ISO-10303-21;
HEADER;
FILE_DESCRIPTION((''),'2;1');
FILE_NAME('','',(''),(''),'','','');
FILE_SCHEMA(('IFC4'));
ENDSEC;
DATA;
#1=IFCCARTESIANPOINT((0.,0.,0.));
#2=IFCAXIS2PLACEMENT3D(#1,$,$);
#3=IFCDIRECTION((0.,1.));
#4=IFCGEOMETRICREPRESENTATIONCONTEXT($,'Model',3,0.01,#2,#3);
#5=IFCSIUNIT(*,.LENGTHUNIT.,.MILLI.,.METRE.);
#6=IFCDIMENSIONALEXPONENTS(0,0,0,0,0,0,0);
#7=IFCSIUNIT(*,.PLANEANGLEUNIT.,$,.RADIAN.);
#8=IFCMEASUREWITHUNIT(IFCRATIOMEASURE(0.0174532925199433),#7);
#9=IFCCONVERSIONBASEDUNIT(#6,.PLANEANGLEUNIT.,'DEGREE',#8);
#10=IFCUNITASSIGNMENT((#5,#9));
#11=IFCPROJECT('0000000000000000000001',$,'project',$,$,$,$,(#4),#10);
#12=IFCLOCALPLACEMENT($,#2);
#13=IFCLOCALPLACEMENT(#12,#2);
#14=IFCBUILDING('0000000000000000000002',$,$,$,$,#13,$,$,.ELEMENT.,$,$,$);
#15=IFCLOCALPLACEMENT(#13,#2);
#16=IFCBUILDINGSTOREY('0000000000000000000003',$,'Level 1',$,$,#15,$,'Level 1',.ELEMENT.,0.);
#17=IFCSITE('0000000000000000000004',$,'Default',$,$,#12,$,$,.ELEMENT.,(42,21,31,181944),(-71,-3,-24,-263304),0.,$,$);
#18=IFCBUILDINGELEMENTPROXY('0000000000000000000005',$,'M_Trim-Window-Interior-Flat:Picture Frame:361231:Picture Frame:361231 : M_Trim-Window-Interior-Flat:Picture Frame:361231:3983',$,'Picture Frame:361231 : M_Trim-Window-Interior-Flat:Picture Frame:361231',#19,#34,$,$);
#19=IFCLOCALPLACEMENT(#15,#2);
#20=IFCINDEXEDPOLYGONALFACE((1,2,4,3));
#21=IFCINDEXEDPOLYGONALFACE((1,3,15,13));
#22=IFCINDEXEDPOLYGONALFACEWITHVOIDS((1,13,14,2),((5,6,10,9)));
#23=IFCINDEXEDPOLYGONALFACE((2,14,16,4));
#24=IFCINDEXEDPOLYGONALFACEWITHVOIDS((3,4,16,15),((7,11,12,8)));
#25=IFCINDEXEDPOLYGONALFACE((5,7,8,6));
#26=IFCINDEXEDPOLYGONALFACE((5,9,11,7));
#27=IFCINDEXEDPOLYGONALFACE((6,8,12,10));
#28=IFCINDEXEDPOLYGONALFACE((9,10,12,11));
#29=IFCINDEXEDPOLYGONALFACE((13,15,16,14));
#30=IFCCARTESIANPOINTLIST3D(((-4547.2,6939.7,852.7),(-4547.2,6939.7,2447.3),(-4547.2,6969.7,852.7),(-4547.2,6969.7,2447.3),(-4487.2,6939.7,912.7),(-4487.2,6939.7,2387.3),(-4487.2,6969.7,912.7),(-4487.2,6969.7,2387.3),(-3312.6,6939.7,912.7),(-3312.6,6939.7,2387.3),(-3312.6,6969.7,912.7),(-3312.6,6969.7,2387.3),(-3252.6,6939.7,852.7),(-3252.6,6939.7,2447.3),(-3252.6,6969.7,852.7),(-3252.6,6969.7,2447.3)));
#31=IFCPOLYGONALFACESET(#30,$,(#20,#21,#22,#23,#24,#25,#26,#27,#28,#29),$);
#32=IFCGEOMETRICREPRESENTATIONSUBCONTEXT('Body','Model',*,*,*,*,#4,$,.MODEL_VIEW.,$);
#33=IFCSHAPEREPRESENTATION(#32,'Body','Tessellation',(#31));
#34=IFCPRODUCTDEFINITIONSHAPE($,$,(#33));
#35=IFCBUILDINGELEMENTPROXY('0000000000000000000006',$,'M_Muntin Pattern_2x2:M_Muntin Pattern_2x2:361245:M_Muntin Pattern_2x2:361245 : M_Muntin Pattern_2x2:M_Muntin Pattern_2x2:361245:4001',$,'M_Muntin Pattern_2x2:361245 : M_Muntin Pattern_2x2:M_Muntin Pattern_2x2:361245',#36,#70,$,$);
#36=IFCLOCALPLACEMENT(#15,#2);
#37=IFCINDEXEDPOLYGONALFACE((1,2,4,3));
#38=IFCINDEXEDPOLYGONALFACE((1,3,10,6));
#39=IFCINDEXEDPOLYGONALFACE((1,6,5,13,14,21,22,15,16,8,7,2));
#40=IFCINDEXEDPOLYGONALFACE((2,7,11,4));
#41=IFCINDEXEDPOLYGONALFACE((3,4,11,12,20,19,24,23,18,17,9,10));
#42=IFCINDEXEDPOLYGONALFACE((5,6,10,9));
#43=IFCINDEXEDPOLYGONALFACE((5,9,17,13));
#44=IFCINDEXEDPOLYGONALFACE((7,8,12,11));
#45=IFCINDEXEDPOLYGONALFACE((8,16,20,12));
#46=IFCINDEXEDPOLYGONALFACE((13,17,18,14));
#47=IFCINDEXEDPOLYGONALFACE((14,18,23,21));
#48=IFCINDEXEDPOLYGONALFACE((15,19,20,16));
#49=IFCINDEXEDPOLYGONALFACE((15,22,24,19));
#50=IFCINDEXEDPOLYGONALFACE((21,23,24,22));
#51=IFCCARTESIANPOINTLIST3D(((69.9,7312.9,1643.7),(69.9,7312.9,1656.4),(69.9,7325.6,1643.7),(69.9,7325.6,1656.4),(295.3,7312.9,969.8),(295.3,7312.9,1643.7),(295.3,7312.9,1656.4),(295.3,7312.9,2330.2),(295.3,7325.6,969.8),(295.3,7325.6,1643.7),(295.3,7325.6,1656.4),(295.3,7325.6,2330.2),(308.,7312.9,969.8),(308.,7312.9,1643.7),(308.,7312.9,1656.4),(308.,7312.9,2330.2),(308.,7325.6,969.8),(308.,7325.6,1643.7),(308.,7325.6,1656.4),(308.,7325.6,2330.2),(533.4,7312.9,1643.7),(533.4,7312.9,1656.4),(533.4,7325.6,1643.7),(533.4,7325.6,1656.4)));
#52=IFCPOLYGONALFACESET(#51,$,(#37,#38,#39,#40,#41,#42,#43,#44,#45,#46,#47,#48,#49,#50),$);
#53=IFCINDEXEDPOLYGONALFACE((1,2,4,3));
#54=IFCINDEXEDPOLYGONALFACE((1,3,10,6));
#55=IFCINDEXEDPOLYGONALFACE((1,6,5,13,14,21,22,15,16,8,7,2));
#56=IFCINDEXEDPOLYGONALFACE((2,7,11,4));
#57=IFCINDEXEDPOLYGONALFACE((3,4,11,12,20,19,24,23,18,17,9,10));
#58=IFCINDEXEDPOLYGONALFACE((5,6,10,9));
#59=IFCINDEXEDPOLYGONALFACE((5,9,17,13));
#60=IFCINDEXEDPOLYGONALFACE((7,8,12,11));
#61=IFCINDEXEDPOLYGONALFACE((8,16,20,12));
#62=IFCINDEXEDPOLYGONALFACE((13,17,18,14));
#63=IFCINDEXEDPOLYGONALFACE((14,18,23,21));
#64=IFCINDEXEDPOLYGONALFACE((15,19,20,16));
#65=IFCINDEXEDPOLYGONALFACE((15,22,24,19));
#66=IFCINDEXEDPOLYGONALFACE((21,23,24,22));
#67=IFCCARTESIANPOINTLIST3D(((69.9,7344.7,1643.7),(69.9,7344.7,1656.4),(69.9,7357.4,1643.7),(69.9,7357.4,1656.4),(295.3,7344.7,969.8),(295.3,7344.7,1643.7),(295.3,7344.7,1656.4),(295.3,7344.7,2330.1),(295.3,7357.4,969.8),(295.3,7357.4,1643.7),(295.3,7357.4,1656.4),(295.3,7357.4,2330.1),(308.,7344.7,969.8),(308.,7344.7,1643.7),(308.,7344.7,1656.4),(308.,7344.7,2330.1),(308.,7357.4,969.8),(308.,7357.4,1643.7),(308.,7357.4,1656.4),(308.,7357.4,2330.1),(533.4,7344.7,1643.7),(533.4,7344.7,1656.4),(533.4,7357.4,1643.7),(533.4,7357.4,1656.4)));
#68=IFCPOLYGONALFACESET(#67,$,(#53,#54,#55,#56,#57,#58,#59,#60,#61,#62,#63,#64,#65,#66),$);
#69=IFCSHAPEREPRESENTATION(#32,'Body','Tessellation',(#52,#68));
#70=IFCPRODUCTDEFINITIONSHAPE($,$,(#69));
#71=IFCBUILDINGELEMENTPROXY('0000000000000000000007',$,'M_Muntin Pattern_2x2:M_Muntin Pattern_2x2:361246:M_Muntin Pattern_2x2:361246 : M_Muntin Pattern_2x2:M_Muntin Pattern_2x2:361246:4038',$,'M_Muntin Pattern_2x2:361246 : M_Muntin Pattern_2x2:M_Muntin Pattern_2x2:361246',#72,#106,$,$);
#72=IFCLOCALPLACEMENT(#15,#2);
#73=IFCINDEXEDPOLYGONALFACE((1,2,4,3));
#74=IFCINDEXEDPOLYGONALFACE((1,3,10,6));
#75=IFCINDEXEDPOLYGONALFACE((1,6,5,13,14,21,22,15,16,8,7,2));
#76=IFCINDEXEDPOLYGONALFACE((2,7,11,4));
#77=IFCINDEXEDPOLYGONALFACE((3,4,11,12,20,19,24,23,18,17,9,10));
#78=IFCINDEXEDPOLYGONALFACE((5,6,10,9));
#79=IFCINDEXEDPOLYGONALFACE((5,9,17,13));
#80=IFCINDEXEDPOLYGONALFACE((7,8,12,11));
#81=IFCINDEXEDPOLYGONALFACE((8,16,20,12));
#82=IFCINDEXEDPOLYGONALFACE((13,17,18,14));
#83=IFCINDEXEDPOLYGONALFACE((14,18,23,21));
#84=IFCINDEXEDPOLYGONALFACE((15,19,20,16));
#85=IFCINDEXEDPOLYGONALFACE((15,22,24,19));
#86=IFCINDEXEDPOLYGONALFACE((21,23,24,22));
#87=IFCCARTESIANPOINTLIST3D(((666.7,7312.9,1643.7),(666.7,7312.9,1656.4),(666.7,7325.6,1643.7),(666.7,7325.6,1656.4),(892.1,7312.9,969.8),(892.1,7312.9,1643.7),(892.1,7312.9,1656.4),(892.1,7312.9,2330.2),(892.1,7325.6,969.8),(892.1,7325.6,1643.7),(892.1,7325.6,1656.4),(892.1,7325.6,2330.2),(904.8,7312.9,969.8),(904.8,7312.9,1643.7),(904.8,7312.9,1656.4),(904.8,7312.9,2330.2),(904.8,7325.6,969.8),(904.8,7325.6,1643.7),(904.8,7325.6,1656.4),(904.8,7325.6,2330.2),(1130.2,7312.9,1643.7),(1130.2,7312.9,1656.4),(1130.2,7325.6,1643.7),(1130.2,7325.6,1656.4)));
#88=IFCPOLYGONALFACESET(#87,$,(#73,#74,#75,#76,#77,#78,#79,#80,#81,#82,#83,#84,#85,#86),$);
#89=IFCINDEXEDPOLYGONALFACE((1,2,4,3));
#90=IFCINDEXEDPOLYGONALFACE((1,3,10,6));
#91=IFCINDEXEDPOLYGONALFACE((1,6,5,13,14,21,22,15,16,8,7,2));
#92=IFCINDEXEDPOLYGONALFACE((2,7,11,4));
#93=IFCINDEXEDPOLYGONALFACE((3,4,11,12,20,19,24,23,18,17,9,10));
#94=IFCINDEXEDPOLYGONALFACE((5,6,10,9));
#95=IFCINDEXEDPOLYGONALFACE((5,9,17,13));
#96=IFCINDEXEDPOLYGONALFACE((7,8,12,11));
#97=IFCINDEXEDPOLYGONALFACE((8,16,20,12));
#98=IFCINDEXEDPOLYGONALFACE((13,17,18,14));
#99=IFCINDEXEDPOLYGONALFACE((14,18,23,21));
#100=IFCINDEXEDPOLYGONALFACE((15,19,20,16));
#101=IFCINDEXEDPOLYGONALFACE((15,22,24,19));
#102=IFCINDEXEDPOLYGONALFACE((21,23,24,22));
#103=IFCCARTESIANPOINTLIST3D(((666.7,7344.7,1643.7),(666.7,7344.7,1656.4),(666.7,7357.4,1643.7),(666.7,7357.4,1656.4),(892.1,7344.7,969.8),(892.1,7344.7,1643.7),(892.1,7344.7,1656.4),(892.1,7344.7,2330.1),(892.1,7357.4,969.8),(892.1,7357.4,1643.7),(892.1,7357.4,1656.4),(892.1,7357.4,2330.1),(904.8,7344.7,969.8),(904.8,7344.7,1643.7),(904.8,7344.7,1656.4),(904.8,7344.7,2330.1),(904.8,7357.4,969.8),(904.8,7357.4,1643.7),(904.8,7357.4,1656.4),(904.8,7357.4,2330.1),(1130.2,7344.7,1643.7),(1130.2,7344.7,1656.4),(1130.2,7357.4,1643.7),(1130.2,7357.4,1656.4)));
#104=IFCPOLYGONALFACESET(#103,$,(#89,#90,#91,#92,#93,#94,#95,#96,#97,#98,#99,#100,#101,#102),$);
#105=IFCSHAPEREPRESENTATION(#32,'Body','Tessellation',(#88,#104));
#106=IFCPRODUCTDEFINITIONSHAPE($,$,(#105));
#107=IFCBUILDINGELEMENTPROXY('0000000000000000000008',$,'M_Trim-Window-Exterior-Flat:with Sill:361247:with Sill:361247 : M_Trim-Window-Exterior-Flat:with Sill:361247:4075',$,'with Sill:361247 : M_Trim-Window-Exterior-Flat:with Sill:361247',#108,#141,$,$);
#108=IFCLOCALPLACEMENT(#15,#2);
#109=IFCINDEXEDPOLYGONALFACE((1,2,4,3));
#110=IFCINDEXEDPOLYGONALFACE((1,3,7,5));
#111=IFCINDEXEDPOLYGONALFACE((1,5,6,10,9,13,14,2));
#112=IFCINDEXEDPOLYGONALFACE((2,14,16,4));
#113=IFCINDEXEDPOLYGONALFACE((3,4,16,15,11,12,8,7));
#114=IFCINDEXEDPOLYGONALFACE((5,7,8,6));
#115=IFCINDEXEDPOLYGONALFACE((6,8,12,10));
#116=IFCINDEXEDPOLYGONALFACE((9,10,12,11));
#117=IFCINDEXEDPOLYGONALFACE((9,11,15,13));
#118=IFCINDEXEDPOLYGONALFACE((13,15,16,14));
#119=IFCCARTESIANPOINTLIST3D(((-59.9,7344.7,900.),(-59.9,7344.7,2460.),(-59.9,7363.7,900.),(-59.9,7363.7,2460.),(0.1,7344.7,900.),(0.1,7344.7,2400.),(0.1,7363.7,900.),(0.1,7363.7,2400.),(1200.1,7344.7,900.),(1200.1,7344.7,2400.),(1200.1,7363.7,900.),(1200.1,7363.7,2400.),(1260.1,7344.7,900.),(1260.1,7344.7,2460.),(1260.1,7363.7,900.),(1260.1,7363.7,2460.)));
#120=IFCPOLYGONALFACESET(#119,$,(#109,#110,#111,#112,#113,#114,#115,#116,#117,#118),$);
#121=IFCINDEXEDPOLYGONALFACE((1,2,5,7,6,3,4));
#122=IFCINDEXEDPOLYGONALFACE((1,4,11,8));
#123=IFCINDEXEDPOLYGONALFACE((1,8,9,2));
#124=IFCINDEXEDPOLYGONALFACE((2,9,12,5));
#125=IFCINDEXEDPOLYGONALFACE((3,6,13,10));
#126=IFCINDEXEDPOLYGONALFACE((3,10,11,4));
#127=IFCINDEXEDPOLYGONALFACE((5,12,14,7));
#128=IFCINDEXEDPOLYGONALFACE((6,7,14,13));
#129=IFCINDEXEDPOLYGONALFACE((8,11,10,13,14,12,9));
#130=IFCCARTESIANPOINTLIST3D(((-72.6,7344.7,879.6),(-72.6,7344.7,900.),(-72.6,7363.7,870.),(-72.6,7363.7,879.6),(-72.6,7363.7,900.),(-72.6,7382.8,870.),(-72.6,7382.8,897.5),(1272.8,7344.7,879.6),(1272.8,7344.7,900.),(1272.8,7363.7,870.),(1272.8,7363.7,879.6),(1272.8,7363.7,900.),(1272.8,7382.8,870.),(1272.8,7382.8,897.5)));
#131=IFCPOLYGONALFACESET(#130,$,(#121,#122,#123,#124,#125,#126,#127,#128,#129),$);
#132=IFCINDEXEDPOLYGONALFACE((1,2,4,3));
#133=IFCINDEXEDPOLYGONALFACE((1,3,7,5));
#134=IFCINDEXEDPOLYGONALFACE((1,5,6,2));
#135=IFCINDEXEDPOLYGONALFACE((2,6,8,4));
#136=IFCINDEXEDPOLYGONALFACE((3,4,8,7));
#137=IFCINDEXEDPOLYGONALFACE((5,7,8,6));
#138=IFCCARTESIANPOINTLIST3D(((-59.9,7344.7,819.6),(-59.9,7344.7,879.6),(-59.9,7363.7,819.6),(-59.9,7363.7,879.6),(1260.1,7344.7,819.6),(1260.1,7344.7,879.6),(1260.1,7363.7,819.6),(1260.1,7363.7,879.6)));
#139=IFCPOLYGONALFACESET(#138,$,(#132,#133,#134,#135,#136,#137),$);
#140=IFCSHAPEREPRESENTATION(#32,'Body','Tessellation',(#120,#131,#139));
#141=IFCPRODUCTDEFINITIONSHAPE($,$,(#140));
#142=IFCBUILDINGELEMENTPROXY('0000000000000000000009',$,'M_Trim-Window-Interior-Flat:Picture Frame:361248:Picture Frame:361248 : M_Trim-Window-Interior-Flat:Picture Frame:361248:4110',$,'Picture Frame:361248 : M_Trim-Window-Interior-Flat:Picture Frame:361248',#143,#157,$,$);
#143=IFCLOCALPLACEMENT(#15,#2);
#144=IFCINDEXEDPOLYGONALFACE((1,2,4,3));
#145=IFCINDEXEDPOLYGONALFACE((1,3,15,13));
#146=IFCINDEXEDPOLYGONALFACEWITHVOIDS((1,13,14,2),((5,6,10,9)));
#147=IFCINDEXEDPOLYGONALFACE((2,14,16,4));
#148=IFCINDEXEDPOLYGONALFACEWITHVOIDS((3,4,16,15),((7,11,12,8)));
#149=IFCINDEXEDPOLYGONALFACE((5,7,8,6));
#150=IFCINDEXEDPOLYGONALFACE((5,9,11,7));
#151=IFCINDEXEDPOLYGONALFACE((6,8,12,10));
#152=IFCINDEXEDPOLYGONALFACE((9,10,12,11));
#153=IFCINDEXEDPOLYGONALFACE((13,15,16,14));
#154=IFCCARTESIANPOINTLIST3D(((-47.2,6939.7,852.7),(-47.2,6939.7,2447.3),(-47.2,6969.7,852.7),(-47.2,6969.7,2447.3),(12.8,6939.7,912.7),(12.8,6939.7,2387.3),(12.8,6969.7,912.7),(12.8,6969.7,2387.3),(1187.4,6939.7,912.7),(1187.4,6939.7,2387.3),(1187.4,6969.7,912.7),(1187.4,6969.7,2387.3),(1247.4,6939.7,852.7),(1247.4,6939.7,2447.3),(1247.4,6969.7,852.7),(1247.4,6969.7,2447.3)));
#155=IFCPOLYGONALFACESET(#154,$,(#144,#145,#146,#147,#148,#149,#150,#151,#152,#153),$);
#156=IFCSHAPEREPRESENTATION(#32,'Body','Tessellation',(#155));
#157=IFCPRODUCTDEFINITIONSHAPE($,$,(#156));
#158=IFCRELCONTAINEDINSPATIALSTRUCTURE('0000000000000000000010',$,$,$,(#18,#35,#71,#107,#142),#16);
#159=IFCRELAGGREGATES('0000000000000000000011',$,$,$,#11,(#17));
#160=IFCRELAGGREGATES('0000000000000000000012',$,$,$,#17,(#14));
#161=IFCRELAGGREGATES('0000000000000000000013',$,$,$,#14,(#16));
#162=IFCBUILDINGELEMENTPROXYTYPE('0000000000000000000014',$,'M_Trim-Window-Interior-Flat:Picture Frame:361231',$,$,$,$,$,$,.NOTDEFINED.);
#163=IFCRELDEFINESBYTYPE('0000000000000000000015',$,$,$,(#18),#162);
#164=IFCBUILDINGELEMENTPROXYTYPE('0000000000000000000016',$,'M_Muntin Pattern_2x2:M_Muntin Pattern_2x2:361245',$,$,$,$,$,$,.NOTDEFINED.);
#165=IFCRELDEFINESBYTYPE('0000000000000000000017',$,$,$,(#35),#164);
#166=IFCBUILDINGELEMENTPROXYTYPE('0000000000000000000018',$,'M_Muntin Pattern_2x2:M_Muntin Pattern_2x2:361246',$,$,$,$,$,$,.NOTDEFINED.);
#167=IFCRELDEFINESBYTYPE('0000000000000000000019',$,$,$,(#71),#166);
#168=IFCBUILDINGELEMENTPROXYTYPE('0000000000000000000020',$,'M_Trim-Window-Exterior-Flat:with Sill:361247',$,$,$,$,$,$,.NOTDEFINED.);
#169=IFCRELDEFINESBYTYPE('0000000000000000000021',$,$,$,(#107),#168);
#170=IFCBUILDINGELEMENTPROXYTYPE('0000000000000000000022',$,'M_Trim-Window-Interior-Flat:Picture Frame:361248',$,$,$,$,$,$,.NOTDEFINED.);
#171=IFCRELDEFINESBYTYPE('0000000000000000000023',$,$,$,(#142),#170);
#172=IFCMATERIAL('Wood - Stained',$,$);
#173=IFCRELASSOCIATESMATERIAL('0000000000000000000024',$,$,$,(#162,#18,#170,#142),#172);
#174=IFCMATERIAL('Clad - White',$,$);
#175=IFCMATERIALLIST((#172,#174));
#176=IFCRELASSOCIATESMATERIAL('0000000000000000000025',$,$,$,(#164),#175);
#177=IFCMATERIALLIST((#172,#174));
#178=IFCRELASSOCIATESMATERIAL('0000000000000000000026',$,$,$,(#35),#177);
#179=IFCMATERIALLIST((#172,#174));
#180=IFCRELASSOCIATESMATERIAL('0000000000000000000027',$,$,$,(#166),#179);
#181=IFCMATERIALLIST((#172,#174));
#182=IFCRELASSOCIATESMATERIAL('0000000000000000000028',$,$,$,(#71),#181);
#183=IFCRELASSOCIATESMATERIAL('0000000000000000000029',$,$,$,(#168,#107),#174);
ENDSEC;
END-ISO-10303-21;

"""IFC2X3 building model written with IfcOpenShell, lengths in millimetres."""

from ifc_helpers import new_model, entity, si_unit, converted_unit, direction, frame, origin, origin_2d_with_axis, place, context, subcontext, project, spatial, polyline, rectangle, outline, extrude, source, transform, mapped, material, material_list, type_object, type_shapes, element, save


model = new_model("IFC2X3")

# Units and contexts
model_context = context("Model", 3, precision=0.01, world=origin(), true_north=direction((0.0, 1.0)))
body_context = subcontext(model_context, "Body", "Model", "MODEL_VIEW")
ifc_project = project(units=[si_unit("LENGTHUNIT", "METRE", prefix="MILLI"), converted_unit("PLANEANGLEUNIT", "DEGREE", entity("IfcRatioMeasure", 0.0174532925199433), si_unit("PLANEANGLEUNIT", "RADIAN"), dimensions=[0, 0, 0, 0, 0, 0, 0])], contexts=[model_context])

# Site, building, storey
site_placement = place(None, origin())
site = spatial("IfcSite", under=ifc_project, at=site_placement, Name="Default", CompositionType="ELEMENT", RefLatitude=(42, 21, 31, 181944), RefLongitude=(-71, -3, -24, -263304), RefElevation=0.0)
building_placement = place(site_placement, origin())
building = spatial("IfcBuilding", under=site, at=building_placement, CompositionType="ELEMENT")
storey_placement = place(building_placement, origin())
storey = spatial("IfcBuildingStorey", under=building, at=storey_placement, Name="Level 1", LongName="Level 1", CompositionType="ELEMENT", Elevation=0.0)

# Building element proxies
ifc_material_1 = material(Name="Wood - Stained")
ifc_material_2 = material(Name="Clad - White")
building_element_proxy_type_1 = type_object("IfcBuildingElementProxyType", Name="M_Trim-Window-Interior-Flat:Picture Frame:361231", PredefinedType="NOTDEFINED", material=ifc_material_1)
shared_shape_1 = source(origin(), body_context, "Body", "SweptSolid", [
    extrude(outline(polyline([(-647.3, -797.3), (647.3, -797.3), (647.3, 797.3), (-647.3, 797.3), (-647.3, -797.3)]), holes=[polyline([(587.3, 737.3), (587.3, -737.3), (-587.3, -737.3), (-587.3, 737.3), (587.3, 737.3)])]), frame((-3899.9, 6939.7, 1650.0), z_axis=(0.0, 1.0, 0.0), x_axis=(1.0, 0.0, 0.0)), (0.0, 0.0, 1.0), 30.0),
])
type_shapes(building_element_proxy_type_1, [shared_shape_1])
proxy_1_placement = place(storey_placement, origin())
element("IfcBuildingElementProxy", 1, at=proxy_1_placement, inside=storey, type_object=building_element_proxy_type_1, material=ifc_material_1, Name="M_Trim-Window-Interior-Flat:Picture Frame:361231:Picture Frame:361231 : M_Trim-Window-Interior-Flat:Picture Frame:361231:3983", ObjectType="Picture Frame:361231 : M_Trim-Window-Interior-Flat:Picture Frame:361231", context=body_context, shape_type="MappedRepresentation", body=[
    mapped(shared_shape_1, transform((0.0, 0.0, 0.0), scale=1.0)),
])
ifc_material_list_1 = material_list([ifc_material_1, ifc_material_2])
ifc_material_list_2 = material_list([ifc_material_1, ifc_material_2])
building_element_proxy_type_2 = type_object("IfcBuildingElementProxyType", Name="M_Muntin Pattern_2x2:M_Muntin Pattern_2x2:361245", PredefinedType="NOTDEFINED", material=ifc_material_list_2)
shared_shape_2 = source(origin(), body_context, "Body", "SweptSolid", [
    extrude(outline(polyline([(-6.4, -680.2), (6.3, -680.2), (6.3, -6.4), (231.7, -6.4), (231.7, 6.3), (6.3, 6.3), (6.3, 680.2), (-6.4, 680.2), (-6.4, 6.3), (-231.7, 6.3), (-231.7, -6.4), (-6.4, -6.4), (-6.4, -680.2)])), frame((301.6, 7312.9, 1650.0), z_axis=(0.0, 1.0, 0.0), x_axis=(1.0, 0.0, 0.0)), (0.0, 0.0, 1.0), 12.7),
    extrude(outline(polyline([(-6.4, -680.1), (6.3, -680.1), (6.3, -6.4), (231.7, -6.4), (231.7, 6.3), (6.3, 6.3), (6.3, 680.2), (-6.4, 680.2), (-6.4, 6.3), (-231.7, 6.3), (-231.7, -6.4), (-6.4, -6.4), (-6.4, -680.1)])), frame((301.6, 7344.7, 1650.0), z_axis=(0.0, 1.0, 0.0), x_axis=(1.0, 0.0, 0.0)), (0.0, 0.0, 1.0), 12.7),
])
type_shapes(building_element_proxy_type_2, [shared_shape_2])
proxy_2_placement = place(storey_placement, origin())
element("IfcBuildingElementProxy", 2, at=proxy_2_placement, inside=storey, type_object=building_element_proxy_type_2, material=ifc_material_list_1, Name="M_Muntin Pattern_2x2:M_Muntin Pattern_2x2:361245:M_Muntin Pattern_2x2:361245 : M_Muntin Pattern_2x2:M_Muntin Pattern_2x2:361245:4001", ObjectType="M_Muntin Pattern_2x2:361245 : M_Muntin Pattern_2x2:M_Muntin Pattern_2x2:361245", context=body_context, shape_type="MappedRepresentation", body=[
    mapped(shared_shape_2, transform((0.0, 0.0, 0.0), scale=1.0)),
])
ifc_material_list_3 = material_list([ifc_material_1, ifc_material_2])
ifc_material_list_4 = material_list([ifc_material_1, ifc_material_2])
building_element_proxy_type_3 = type_object("IfcBuildingElementProxyType", Name="M_Muntin Pattern_2x2:M_Muntin Pattern_2x2:361246", PredefinedType="NOTDEFINED", material=ifc_material_list_4)
shared_shape_3 = source(origin(), body_context, "Body", "SweptSolid", [
    extrude(outline(polyline([(-680.1, 6.4), (-680.1, -6.3), (-6.4, -6.3), (-6.4, -231.7), (6.3, -231.7), (6.3, -6.3), (680.2, -6.3), (680.2, 6.4), (6.3, 6.4), (6.3, 231.7), (-6.4, 231.7), (-6.4, 6.4), (-680.1, 6.4)])), frame((898.5, 7312.9, 1650.0), z_axis=(0.0, -1.0, 0.0), x_axis=(0.0, 0.0, -1.0)), (0.0, 0.0, -1.0), 12.7),
    extrude(outline(polyline([(-680.1, 6.4), (-680.1, -6.3), (-6.4, -6.3), (-6.4, -231.7), (6.3, -231.7), (6.3, -6.3), (680.2, -6.3), (680.2, 6.4), (6.3, 6.4), (6.3, 231.7), (-6.4, 231.7), (-6.4, 6.4), (-680.1, 6.4)])), frame((898.5, 7344.7, 1650.0), z_axis=(0.0, -1.0, 0.0), x_axis=(0.0, 0.0, -1.0)), (0.0, 0.0, -1.0), 12.7),
])
type_shapes(building_element_proxy_type_3, [shared_shape_3])
proxy_3_placement = place(storey_placement, origin())
element("IfcBuildingElementProxy", 3, at=proxy_3_placement, inside=storey, type_object=building_element_proxy_type_3, material=ifc_material_list_3, Name="M_Muntin Pattern_2x2:M_Muntin Pattern_2x2:361246:M_Muntin Pattern_2x2:361246 : M_Muntin Pattern_2x2:M_Muntin Pattern_2x2:361246:4038", ObjectType="M_Muntin Pattern_2x2:361246 : M_Muntin Pattern_2x2:M_Muntin Pattern_2x2:361246", context=body_context, shape_type="MappedRepresentation", body=[
    mapped(shared_shape_3, transform((0.0, 0.0, 0.0), scale=1.0)),
])
building_element_proxy_type_4 = type_object("IfcBuildingElementProxyType", Name="M_Trim-Window-Exterior-Flat:with Sill:361247", PredefinedType="NOTDEFINED", material=ifc_material_2)
shared_shape_4 = source(origin(), body_context, "Body", "SweptSolid", [
    extrude(outline(polyline([(-660.0, -765.0), (-600.0, -765.0), (-600.0, 735.0), (600.0, 735.0), (600.0, -765.0), (660.0, -765.0), (660.0, 795.0), (-660.0, 795.0), (-660.0, -765.0)])), frame((600.1, 7344.7, 1665.0), z_axis=(0.0, 1.0, 0.0), x_axis=(-1.0, 0.0, 0.0)), (0.0, 0.0, 1.0), 19.1),
    extrude(outline(polyline([(0.0, -15.2), (19.0, -15.2), (19.0, 12.3), (0.0, 14.8), (-19.0, 14.8), (-19.0, -5.7), (0.0, -5.7), (0.0, -15.2)])), frame((-72.6, 7363.7, 885.2), z_axis=(1.0, 0.0, 0.0), x_axis=(0.0, 1.0, 0.0)), (0.0, 0.0, 1.0), 1345.4),
    extrude(rectangle(XDim=19.1, YDim=1320.0, at=origin_2d_with_axis()), frame((600.1, 7354.2, 819.6), z_axis=(0.0, 0.0, 1.0), x_axis=(0.0, -1.0, 0.0)), (0.0, 0.0, 1.0), 60.0),
])
type_shapes(building_element_proxy_type_4, [shared_shape_4])
proxy_4_placement = place(storey_placement, origin())
element("IfcBuildingElementProxy", 4, at=proxy_4_placement, inside=storey, type_object=building_element_proxy_type_4, material=ifc_material_2, Name="M_Trim-Window-Exterior-Flat:with Sill:361247:with Sill:361247 : M_Trim-Window-Exterior-Flat:with Sill:361247:4075", ObjectType="with Sill:361247 : M_Trim-Window-Exterior-Flat:with Sill:361247", context=body_context, shape_type="MappedRepresentation", body=[
    mapped(shared_shape_4, transform((0.0, 0.0, 0.0), scale=1.0)),
])
building_element_proxy_type_5 = type_object("IfcBuildingElementProxyType", Name="M_Trim-Window-Interior-Flat:Picture Frame:361248", PredefinedType="NOTDEFINED", material=ifc_material_1)
shared_shape_5 = source(origin(), body_context, "Body", "SweptSolid", [
    extrude(outline(polyline([(-647.3, -797.3), (647.3, -797.3), (647.3, 797.3), (-647.3, 797.3), (-647.3, -797.3)]), holes=[polyline([(587.3, 737.3), (587.3, -737.3), (-587.3, -737.3), (-587.3, 737.3), (587.3, 737.3)])]), frame((600.1, 6939.7, 1650.0), z_axis=(0.0, 1.0, 0.0), x_axis=(1.0, 0.0, 0.0)), (0.0, 0.0, 1.0), 30.0),
])
type_shapes(building_element_proxy_type_5, [shared_shape_5])
proxy_5_placement = place(storey_placement, origin())
element("IfcBuildingElementProxy", 5, at=proxy_5_placement, inside=storey, type_object=building_element_proxy_type_5, material=ifc_material_1, Name="M_Trim-Window-Interior-Flat:Picture Frame:361248:Picture Frame:361248 : M_Trim-Window-Interior-Flat:Picture Frame:361248:4110", ObjectType="Picture Frame:361248 : M_Trim-Window-Interior-Flat:Picture Frame:361248", context=body_context, shape_type="MappedRepresentation", body=[
    mapped(shared_shape_5, transform((0.0, 0.0, 0.0), scale=1.0)),
])

save(model, "model.ifc")
